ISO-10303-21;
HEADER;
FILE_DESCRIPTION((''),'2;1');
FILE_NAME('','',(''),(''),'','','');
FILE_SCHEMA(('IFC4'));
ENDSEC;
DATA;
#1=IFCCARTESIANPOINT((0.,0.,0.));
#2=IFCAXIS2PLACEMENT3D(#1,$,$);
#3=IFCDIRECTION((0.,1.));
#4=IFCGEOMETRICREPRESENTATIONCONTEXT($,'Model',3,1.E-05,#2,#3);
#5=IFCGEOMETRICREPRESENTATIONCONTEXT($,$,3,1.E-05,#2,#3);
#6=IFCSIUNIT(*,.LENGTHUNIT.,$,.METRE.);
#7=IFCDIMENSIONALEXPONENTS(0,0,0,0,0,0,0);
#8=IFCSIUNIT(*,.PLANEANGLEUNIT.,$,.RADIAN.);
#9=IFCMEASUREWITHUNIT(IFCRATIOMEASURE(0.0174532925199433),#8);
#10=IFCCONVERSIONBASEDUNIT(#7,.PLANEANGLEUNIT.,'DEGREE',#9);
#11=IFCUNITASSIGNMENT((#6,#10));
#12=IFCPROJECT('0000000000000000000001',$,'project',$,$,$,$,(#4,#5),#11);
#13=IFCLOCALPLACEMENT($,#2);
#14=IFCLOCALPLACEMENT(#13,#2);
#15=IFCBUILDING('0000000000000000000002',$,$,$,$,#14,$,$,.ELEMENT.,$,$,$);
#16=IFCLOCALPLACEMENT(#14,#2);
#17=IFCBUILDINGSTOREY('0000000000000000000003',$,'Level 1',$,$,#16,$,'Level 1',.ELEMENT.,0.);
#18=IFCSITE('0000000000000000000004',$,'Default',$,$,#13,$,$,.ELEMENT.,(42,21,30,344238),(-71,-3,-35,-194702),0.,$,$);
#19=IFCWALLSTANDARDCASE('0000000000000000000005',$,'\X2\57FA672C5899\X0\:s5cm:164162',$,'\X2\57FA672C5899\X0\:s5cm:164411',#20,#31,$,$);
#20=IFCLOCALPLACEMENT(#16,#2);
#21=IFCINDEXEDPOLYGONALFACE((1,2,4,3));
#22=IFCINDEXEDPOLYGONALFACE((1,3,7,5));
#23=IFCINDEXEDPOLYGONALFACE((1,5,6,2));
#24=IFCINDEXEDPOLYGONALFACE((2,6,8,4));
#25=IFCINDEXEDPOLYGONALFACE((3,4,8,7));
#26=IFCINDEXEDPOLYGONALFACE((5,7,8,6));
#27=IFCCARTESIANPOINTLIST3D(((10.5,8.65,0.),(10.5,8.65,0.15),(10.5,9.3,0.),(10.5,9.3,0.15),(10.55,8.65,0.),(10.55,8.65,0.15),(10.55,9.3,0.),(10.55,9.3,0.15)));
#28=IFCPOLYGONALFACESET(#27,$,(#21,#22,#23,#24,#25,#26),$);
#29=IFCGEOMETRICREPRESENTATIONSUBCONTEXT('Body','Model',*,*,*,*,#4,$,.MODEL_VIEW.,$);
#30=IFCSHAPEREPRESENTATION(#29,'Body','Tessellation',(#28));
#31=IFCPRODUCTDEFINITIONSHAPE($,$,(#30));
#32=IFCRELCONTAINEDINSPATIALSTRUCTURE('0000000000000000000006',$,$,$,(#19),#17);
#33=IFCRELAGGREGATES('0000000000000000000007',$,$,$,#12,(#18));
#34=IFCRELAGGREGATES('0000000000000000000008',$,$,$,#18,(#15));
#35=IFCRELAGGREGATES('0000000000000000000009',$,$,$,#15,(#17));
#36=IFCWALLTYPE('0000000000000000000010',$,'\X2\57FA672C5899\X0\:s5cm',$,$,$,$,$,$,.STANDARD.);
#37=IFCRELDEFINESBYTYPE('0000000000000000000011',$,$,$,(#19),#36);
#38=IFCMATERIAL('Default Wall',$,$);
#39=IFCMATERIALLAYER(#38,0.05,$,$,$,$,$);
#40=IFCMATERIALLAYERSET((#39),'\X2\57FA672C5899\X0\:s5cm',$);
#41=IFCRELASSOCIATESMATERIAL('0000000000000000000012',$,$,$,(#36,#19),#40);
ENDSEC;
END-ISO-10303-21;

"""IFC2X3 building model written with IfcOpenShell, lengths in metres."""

from ifc_helpers import new_model, entity, si_unit, converted_unit, direction, frame, frame_2d, origin, place, context, subcontext, project, spatial, rectangle, extrude, material, layer, layer_set, layer_usage, type_object, element, save


model = new_model("IFC2X3")

# Units and contexts
model_context = context("Model", 3, precision=1e-05, world=origin(), true_north=direction((0.0, 1.0)))
context_of_model = context(None, 3, precision=1e-05, world=origin(), true_north=direction((0.0, 1.0)))
body_context = subcontext(model_context, "Body", "Model", "MODEL_VIEW")
ifc_project = project(units=[si_unit("LENGTHUNIT", "METRE"), converted_unit("PLANEANGLEUNIT", "DEGREE", entity("IfcRatioMeasure", 0.0174532925199433), si_unit("PLANEANGLEUNIT", "RADIAN"), dimensions=[0, 0, 0, 0, 0, 0, 0])], contexts=[model_context, context_of_model])

# Site, building, storey
site_placement = place(None, origin())
site = spatial("IfcSite", under=ifc_project, at=site_placement, Name="Default", CompositionType="ELEMENT", RefLatitude=(42, 21, 30, 344238), RefLongitude=(-71, -3, -35, -194702), RefElevation=0.0)
building_placement = place(site_placement, origin())
building = spatial("IfcBuilding", under=site, at=building_placement, CompositionType="ELEMENT")
storey_placement = place(building_placement, origin())
storey = spatial("IfcBuildingStorey", under=building, at=storey_placement, Name="Level 1", LongName="Level 1", CompositionType="ELEMENT", Elevation=0.0)

# Wall
ifc_material = material(Name="Default Wall")
ifc_layer = layer(ifc_material, 0.05)
ifc_layer_set = layer_set([ifc_layer], Name="基本墙:s5cm")
wall_type = type_object("IfcWallType", Name="基本墙:s5cm", PredefinedType="STANDARD", material=ifc_layer_set)
ifc_layer_usage_1 = layer_usage(ifc_layer_set, "AXIS2", "NEGATIVE", 0.025)
wall_1_placement = place(storey_placement, frame((10.525, 9.3, 0.0), z_axis=(0.0, 0.0, 1.0), x_axis=(0.0, -1.0, 0.0)))
element("IfcWallStandardCase", 1, at=wall_1_placement, inside=storey, type_object=wall_type, material=ifc_layer_usage_1, Name="基本墙:s5cm:164162", ObjectType="基本墙:s5cm:164411", context=body_context, shape_type="SweptSolid", body=[
    extrude(rectangle(XDim=0.65, YDim=0.05, at=frame_2d((0.325, 0.0), x_axis=(-1.0, 0.0))), origin(), (0.0, 0.0, 1.0), 0.15),
])

save(model, "model.ifc")
